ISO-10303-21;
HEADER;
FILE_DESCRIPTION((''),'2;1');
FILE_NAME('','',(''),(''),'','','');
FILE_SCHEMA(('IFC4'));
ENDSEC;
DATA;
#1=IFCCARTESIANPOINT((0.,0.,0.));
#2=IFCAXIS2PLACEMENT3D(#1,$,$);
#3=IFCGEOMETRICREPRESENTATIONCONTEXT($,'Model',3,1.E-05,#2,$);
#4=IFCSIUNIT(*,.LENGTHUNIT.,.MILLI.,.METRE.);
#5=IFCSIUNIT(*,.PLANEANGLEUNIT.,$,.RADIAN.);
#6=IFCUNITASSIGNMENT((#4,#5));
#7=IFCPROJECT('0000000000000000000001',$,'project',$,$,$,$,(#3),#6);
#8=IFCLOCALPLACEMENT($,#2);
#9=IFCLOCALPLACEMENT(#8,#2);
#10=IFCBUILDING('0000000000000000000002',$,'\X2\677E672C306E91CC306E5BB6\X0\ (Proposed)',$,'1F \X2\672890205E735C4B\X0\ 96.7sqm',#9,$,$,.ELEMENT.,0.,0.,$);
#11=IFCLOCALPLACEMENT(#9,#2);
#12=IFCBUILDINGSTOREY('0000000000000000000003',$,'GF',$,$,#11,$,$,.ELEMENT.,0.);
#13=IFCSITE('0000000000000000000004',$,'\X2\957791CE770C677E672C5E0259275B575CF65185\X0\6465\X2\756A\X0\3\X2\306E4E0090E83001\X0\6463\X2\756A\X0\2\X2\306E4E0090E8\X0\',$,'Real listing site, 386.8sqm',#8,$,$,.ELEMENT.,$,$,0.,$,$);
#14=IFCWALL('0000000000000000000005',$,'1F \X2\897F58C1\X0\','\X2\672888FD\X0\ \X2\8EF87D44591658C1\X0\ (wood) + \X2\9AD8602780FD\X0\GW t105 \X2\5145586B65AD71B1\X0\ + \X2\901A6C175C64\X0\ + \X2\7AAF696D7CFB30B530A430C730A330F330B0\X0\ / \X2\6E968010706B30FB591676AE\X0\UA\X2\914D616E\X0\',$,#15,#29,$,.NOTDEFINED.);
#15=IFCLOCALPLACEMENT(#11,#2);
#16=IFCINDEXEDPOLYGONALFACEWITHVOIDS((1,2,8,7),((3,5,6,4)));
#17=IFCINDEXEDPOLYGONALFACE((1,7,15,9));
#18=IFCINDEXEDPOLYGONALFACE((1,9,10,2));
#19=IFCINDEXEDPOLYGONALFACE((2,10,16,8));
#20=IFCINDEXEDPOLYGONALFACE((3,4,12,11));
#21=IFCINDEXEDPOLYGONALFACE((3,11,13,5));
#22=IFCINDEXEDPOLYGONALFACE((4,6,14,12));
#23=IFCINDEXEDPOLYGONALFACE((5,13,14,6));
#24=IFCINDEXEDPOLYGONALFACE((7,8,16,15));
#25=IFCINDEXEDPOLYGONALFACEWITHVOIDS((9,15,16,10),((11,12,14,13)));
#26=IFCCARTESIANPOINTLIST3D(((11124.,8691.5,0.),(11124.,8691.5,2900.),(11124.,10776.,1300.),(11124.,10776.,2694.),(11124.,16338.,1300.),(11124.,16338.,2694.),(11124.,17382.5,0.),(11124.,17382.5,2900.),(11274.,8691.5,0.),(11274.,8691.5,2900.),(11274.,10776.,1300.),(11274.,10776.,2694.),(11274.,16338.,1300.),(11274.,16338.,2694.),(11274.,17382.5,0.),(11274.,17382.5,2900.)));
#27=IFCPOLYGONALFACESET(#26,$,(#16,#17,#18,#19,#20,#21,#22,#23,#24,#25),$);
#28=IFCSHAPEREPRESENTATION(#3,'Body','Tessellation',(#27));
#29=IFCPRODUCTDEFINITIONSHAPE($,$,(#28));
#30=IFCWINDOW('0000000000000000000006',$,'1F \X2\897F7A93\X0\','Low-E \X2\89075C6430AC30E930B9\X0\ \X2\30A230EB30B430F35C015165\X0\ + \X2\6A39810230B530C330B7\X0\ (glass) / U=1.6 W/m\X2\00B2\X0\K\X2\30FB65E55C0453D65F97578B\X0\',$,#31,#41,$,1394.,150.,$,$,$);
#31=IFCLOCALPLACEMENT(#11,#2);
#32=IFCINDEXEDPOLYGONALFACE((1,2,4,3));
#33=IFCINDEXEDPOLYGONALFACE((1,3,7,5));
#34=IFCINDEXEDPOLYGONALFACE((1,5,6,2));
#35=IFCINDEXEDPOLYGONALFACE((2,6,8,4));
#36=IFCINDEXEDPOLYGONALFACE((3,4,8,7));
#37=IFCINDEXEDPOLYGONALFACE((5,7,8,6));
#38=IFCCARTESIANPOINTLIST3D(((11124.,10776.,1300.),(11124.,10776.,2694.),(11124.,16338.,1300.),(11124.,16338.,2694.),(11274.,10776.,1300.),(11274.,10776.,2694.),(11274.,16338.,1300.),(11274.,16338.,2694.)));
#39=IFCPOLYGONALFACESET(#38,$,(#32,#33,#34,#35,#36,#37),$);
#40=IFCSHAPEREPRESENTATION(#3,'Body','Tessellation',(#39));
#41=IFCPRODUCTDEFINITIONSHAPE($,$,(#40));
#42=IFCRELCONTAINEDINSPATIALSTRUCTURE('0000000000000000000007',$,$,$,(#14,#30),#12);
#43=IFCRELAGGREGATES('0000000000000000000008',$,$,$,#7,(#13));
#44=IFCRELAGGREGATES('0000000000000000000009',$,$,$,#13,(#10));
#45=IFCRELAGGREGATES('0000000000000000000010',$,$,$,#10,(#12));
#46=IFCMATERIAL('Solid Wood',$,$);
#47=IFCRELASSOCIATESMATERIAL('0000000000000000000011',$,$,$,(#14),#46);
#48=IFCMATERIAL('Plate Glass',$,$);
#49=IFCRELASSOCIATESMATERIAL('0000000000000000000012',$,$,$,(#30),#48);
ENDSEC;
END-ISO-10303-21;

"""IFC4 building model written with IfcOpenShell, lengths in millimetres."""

from ifc_helpers import new_model, si_unit, frame, frame_2d, origin, place, context, project, spatial, rectangle, extrude, material, element, fill, save


model = new_model("IFC4")

# Units and contexts
model_context = context("Model", 3, precision=1e-05, world=origin())
ifc_project = project(units=[si_unit("LENGTHUNIT", "METRE", prefix="MILLI"), si_unit("PLANEANGLEUNIT", "RADIAN")], contexts=[model_context])

# Site, building, storey
site_placement = place(None, origin())
site = spatial("IfcSite", under=ifc_project, at=site_placement, Name="長野県松本市大字島内6465番3の一部、6463番2の一部", ObjectType="Real listing site, 386.8sqm", CompositionType="ELEMENT", RefElevation=0.0)
building_placement = place(site_placement, origin())
building = spatial("IfcBuilding", under=site, at=building_placement, Name="松本の里の家 (Proposed)", ObjectType="1F 木造平屋 96.7sqm", CompositionType="ELEMENT", ElevationOfRefHeight=0.0, ElevationOfTerrain=0.0)
storey_placement = place(building_placement, origin())
storey = spatial("IfcBuildingStorey", under=building, at=storey_placement, Name="GF", CompositionType="ELEMENT", Elevation=0.0)

# Shared definitions
ifc_material_1 = material(Name="Solid Wood")

# Shared definitions
ifc_material_2 = material(Name="Plate Glass")

# Wall, opening, window
wall_1_placement = place(storey_placement, frame((5562.0, 4346.0, 0.0)))
wall_1 = element("IfcWall", 1, at=wall_1_placement, inside=storey, material=ifc_material_1, Name="1F 西壁", Description="木製 軸組外壁 (wood) + 高性能GW t105 充填断熱 + 通気層 + 窯業系サイディング / 準耐火・外皮UA配慮", PredefinedType="NOTDEFINED", context=model_context, shape_type="SweptSolid", body=[
    extrude(rectangle(XDim=150.0, YDim=8691.0, at=frame_2d((75.0, 4345.0))), frame((5562.0, 4346.0, 0.0)), (0.0, 0.0, 1.0), 2900.0),
])
opening_1_placement = place(storey_placement, frame((5562.0, 5388.0, 650.0)))
opening_1 = element("IfcOpeningElement", 2, at=opening_1_placement, cuts=wall_1, PredefinedType="NOTDEFINED", context=model_context, shape_type="SweptSolid", body=[
    extrude(rectangle(XDim=150.0, YDim=5562.0, at=frame_2d((75.0, 2781.0))), frame((5562.0, 5388.0, 650.0)), (0.0, 0.0, 1.0), 1394.0),
])
window_1_placement = place(storey_placement, frame((5562.0, 5388.0, 650.0)))
window_1 = element("IfcWindow", 3, at=window_1_placement, inside=storey, material=ifc_material_2, Name="1F 西窓", Description="Low-E 複層ガラス アルゴン封入 + 樹脂サッシ (glass) / U=1.6 W/m²K・日射取得型", OverallHeight=1394.0, OverallWidth=150.0, context=model_context, shape_type="SweptSolid", body=[
    extrude(rectangle(XDim=150.0, YDim=5562.0, at=frame_2d((75.0, 2781.0))), frame((5562.0, 5388.0, 650.0)), (0.0, 0.0, 1.0), 1394.0),
])
fill(opening_1, window_1)

save(model, "model.ifc")
